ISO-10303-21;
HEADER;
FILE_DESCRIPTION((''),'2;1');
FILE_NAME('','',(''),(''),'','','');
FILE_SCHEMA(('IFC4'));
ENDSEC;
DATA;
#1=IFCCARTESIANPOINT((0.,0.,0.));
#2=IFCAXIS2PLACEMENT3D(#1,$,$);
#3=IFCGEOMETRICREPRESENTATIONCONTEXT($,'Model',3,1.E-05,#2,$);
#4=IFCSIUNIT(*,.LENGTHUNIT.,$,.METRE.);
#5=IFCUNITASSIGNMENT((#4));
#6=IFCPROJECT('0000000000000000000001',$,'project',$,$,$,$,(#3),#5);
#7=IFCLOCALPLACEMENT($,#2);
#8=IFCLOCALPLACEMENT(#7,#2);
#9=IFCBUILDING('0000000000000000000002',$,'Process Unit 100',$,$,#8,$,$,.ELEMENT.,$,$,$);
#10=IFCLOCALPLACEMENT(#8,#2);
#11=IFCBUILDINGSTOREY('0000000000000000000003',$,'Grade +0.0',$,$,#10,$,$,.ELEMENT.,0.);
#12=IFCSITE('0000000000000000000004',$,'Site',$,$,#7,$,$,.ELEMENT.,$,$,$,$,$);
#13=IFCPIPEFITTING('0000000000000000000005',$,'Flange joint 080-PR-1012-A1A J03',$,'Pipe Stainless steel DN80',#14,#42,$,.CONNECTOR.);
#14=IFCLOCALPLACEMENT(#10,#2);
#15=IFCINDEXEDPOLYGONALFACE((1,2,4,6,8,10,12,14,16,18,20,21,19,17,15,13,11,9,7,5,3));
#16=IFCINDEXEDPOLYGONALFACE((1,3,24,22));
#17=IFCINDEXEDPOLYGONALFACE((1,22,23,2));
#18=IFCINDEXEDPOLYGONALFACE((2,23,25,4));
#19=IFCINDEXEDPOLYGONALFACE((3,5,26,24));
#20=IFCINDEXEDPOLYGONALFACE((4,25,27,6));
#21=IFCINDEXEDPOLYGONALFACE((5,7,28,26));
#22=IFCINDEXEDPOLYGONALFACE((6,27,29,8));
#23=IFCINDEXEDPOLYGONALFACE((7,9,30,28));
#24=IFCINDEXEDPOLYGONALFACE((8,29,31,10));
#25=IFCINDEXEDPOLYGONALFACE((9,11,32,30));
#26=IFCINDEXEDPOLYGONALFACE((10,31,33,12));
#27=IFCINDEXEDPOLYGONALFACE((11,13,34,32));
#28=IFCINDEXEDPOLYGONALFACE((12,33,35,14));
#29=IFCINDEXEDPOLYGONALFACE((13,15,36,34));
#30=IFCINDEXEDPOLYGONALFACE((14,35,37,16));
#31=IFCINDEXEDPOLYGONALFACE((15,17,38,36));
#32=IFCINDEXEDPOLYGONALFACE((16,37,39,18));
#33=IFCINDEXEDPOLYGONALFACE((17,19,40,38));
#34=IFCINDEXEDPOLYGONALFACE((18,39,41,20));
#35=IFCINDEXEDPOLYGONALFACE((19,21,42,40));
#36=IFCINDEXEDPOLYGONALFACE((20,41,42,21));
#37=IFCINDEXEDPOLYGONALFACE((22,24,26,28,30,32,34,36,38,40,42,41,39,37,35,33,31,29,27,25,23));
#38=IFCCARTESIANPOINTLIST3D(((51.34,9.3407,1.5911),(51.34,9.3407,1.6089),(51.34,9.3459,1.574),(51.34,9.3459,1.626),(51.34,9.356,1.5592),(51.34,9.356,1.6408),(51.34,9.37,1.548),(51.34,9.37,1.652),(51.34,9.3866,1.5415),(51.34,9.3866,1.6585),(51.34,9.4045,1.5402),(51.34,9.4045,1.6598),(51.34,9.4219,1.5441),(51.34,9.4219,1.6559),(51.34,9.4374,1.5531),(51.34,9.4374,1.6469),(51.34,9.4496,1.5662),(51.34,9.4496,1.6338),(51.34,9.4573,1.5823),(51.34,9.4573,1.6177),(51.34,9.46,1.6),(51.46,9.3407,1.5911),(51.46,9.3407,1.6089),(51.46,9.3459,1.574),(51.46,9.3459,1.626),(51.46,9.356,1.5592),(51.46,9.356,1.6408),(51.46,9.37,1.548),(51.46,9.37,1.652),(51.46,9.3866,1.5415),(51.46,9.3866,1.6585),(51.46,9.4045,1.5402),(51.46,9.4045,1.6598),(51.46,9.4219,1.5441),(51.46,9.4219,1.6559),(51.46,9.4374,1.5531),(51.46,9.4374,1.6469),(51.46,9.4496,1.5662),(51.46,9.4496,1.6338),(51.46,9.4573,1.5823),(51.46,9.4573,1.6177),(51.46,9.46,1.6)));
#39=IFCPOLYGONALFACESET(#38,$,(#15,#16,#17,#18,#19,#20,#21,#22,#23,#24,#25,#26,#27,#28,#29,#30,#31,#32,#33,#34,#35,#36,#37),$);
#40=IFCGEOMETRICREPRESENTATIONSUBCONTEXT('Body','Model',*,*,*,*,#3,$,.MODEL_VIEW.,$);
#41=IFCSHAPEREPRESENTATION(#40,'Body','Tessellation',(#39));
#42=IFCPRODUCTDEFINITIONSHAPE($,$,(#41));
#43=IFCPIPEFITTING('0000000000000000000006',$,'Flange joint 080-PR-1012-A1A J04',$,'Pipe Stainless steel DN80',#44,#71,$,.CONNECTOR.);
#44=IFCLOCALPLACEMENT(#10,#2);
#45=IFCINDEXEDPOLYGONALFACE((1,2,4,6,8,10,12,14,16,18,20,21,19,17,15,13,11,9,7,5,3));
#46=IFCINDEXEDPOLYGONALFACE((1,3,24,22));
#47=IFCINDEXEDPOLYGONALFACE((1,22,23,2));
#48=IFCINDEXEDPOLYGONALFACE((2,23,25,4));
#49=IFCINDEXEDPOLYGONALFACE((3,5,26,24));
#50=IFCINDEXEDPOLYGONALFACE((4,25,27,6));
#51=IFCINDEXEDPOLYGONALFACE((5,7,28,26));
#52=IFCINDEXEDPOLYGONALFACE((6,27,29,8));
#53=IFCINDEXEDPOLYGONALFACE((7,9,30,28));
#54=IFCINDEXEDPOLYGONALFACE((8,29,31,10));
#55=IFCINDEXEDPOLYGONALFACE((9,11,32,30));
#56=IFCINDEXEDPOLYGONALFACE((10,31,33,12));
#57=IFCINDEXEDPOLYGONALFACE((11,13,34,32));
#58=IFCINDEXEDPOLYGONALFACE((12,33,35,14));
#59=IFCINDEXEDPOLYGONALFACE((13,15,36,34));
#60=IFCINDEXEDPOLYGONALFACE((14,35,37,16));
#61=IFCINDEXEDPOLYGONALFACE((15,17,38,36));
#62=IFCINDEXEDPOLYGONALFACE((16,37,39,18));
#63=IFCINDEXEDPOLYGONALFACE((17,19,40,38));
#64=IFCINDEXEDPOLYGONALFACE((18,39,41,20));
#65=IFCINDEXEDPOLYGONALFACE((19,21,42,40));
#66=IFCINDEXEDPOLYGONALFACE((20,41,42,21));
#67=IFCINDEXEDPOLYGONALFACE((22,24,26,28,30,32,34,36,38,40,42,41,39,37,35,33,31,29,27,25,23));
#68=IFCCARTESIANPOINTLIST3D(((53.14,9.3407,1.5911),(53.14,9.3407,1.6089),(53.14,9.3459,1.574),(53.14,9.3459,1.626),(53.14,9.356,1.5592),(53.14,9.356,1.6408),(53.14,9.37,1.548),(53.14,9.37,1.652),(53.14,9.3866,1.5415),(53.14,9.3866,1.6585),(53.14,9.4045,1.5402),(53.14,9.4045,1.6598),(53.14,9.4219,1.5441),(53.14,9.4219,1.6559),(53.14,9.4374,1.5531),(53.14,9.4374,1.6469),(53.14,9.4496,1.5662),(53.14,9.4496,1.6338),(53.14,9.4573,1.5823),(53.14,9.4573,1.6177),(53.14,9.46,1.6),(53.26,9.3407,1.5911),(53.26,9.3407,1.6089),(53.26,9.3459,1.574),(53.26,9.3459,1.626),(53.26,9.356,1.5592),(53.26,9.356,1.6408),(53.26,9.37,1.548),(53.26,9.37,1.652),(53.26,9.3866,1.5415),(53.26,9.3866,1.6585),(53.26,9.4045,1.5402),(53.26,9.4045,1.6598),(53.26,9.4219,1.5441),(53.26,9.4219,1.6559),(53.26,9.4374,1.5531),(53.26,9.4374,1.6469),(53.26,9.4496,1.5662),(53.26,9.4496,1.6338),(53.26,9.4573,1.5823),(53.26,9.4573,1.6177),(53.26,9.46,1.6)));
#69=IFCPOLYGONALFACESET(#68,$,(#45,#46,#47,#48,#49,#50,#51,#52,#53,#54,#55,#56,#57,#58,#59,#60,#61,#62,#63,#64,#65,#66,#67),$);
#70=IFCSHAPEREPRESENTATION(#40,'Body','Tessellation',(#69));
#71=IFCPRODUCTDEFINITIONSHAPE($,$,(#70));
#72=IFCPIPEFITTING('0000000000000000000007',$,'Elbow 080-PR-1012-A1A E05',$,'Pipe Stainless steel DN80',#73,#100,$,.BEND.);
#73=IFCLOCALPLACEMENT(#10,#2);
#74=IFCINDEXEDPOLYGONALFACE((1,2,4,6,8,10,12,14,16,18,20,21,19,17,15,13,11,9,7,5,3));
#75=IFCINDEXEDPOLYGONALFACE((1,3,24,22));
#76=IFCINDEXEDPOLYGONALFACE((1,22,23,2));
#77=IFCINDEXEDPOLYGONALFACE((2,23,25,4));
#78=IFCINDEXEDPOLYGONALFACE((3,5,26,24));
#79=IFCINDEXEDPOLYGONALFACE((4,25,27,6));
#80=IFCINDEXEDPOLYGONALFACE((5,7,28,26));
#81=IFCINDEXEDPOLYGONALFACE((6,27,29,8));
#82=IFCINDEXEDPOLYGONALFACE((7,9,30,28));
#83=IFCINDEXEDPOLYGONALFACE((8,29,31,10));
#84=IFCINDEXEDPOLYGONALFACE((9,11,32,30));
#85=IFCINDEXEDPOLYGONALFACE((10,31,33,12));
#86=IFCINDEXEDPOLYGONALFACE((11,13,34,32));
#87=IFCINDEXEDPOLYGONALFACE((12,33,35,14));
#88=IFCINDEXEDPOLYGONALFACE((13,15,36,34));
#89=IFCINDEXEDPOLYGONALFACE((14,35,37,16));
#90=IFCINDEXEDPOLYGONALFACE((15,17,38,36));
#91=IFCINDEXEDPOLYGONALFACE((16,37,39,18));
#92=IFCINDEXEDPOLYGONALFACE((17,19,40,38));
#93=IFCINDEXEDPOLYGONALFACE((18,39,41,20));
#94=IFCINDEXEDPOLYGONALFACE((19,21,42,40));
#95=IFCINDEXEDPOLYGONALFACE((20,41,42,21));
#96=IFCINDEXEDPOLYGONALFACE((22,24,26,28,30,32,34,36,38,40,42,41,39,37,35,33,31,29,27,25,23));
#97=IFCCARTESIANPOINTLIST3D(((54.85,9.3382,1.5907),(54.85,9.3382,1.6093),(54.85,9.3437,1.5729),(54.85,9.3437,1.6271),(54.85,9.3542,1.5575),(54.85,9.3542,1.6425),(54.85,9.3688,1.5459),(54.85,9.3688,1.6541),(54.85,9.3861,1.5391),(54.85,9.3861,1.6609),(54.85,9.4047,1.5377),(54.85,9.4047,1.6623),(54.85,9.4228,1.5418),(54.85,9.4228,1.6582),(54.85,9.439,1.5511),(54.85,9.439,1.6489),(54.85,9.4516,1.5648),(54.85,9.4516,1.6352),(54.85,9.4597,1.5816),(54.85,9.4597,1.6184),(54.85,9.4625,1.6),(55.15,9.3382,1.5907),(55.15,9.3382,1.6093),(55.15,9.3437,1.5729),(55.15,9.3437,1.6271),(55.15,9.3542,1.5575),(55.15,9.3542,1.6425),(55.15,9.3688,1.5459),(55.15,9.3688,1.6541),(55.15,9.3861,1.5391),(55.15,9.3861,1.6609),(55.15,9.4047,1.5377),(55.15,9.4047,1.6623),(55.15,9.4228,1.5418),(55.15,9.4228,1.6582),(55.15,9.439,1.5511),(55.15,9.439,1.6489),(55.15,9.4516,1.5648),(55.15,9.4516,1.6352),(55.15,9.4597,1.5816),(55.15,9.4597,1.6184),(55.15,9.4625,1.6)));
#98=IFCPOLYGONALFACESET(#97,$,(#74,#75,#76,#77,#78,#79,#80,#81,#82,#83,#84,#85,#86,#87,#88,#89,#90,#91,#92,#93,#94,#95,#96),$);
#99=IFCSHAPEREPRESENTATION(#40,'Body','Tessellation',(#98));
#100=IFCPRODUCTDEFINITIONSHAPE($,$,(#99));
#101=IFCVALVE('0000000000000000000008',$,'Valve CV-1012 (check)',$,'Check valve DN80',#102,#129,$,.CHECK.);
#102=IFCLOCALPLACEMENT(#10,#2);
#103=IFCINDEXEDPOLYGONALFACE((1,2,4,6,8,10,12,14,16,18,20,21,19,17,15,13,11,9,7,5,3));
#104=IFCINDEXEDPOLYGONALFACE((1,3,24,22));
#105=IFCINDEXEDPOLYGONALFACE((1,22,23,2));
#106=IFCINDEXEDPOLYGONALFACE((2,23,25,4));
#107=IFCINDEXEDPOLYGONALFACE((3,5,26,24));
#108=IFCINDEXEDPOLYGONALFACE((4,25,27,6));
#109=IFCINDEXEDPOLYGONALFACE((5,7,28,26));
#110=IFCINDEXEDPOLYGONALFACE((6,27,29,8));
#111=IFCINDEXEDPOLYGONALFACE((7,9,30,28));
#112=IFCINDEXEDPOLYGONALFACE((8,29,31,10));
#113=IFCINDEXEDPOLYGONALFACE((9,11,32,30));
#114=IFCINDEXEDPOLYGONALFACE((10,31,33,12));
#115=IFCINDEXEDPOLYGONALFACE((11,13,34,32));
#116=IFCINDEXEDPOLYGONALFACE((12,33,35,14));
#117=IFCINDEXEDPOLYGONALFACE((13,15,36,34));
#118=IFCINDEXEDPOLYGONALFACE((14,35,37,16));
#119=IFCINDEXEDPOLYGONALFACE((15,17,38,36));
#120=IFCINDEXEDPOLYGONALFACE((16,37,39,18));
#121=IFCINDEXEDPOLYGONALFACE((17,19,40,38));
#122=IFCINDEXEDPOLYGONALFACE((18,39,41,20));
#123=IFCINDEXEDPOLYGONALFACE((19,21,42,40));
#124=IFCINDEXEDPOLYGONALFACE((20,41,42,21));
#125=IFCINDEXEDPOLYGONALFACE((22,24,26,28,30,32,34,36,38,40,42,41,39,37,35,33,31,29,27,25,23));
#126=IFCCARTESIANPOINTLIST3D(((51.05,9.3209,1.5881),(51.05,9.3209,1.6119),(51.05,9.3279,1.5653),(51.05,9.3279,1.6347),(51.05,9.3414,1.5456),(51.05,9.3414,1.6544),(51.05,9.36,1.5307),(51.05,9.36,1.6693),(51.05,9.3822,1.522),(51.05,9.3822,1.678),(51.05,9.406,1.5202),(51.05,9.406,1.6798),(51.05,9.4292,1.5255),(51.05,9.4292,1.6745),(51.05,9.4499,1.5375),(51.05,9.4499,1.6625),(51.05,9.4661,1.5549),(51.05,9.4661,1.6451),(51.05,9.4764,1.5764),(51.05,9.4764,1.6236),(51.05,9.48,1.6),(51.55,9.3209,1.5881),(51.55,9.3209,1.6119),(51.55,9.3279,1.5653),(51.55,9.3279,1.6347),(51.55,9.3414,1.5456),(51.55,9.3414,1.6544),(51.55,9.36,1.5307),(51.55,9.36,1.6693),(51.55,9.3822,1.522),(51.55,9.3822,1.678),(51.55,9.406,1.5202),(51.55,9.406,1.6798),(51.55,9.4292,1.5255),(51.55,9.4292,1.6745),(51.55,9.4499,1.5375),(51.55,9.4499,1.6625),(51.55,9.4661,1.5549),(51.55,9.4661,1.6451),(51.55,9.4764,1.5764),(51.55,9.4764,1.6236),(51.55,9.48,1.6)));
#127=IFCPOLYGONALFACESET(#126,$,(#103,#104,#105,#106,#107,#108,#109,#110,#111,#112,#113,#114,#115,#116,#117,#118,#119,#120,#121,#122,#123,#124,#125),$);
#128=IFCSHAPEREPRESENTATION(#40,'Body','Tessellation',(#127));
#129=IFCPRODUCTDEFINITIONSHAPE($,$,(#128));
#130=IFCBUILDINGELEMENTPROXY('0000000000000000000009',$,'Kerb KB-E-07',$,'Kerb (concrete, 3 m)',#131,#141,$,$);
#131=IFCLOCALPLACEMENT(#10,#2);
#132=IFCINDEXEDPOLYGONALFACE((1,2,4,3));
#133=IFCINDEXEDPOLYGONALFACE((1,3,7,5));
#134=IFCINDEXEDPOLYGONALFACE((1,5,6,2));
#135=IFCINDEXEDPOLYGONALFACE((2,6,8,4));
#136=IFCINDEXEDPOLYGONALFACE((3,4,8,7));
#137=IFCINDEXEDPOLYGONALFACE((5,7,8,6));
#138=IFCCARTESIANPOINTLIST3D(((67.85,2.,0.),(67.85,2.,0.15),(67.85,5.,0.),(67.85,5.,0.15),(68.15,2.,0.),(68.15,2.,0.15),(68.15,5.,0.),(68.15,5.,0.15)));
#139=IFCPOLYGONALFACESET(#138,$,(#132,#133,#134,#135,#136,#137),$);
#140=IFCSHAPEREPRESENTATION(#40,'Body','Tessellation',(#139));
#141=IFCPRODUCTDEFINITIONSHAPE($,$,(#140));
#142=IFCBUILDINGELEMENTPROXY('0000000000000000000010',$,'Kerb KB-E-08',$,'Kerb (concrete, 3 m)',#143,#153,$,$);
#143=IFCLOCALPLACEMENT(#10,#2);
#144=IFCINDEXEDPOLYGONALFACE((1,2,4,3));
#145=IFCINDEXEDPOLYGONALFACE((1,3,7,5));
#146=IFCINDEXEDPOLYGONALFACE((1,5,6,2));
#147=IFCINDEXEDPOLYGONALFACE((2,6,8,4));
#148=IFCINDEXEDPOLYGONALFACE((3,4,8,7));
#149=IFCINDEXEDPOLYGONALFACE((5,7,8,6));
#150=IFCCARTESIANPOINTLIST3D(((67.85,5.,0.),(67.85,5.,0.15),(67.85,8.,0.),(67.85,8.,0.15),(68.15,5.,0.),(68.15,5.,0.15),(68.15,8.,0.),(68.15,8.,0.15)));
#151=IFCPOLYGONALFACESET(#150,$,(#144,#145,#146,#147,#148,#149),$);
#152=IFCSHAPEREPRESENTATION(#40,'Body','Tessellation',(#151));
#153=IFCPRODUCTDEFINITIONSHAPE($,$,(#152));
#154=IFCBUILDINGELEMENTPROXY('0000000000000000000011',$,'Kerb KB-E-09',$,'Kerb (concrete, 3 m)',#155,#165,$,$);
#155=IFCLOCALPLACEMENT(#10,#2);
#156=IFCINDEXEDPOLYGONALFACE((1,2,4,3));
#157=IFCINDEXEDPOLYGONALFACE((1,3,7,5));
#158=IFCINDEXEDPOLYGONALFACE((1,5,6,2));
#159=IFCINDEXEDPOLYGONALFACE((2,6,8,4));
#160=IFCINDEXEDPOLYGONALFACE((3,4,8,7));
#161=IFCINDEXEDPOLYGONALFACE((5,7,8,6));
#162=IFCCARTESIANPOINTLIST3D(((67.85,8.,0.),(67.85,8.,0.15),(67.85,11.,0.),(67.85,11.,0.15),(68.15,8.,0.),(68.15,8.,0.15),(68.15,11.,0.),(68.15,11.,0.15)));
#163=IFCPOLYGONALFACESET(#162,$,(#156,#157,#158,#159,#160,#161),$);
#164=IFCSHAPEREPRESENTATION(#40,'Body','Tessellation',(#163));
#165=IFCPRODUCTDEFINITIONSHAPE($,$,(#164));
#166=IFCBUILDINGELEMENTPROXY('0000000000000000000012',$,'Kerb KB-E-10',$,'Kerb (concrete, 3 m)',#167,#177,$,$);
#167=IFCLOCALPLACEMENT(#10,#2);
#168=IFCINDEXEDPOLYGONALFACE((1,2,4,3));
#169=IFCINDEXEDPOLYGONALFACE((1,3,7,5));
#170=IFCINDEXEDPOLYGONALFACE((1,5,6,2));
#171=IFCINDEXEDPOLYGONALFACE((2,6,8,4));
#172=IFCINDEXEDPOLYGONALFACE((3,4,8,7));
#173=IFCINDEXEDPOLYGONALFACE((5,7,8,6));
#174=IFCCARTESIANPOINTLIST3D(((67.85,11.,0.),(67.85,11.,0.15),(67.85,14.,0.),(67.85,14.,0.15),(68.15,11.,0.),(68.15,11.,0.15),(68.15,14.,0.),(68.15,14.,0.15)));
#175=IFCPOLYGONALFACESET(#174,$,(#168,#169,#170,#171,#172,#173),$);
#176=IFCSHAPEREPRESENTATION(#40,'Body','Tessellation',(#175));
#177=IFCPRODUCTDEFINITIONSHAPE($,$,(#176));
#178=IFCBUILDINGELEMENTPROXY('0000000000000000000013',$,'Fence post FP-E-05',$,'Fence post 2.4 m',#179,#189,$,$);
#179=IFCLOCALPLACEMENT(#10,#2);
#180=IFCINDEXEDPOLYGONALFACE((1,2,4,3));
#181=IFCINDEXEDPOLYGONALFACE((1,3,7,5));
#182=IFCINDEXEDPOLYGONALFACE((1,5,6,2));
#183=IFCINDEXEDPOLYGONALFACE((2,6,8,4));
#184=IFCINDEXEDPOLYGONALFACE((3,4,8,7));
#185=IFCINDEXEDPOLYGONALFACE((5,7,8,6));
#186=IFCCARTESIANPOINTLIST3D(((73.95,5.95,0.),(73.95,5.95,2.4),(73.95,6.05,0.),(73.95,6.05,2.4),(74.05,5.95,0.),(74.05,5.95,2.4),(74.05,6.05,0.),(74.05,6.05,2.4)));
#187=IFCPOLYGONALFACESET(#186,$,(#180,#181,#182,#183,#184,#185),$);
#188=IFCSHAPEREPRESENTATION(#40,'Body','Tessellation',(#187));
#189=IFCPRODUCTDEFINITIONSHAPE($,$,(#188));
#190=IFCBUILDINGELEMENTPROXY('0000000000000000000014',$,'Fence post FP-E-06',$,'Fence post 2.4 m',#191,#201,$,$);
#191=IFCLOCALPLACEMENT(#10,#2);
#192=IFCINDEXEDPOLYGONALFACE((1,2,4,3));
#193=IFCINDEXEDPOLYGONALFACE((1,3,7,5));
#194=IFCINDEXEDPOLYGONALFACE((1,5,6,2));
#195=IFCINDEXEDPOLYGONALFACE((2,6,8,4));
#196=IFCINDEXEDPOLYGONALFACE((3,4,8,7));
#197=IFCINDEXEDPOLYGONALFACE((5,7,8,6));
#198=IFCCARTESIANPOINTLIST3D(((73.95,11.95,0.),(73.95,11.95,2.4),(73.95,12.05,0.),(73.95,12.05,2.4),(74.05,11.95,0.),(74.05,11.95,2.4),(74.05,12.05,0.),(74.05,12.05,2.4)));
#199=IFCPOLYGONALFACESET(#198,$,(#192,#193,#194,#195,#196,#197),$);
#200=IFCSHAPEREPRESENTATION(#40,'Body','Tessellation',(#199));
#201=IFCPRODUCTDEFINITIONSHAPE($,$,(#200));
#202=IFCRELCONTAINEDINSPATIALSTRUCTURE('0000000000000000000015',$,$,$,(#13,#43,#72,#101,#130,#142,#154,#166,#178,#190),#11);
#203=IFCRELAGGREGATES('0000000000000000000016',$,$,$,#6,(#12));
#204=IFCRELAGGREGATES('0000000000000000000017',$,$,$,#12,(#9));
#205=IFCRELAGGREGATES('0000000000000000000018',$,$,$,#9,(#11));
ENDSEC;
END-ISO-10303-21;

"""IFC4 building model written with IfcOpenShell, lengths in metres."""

from ifc_helpers import new_model, si_unit, frame, origin, place, context, subcontext, project, spatial, rectangle, circle, extrude, element, save


model = new_model("IFC4")

# Units and contexts
model_context = context("Model", 3, precision=1e-05, world=origin())
body_context = subcontext(model_context, "Body", "Model", "MODEL_VIEW")
ifc_project = project(units=[si_unit("LENGTHUNIT", "METRE")], contexts=[model_context])

# Site, building, storey
site_placement = place(None, origin())
site = spatial("IfcSite", under=ifc_project, at=site_placement, Name="Site", CompositionType="ELEMENT")
building_placement = place(site_placement, origin())
building = spatial("IfcBuilding", under=site, at=building_placement, Name="Process Unit 100", CompositionType="ELEMENT")
storey_placement = place(building_placement, origin())
storey = spatial("IfcBuildingStorey", under=building, at=storey_placement, Name="Grade +0.0", CompositionType="ELEMENT", Elevation=0.0)

# Pipe fittings
for number, where, z_axis, x_axis, name in (
    (1, (51.34, 9.4, 1.6), (1.0, 0.0, 0.0), (0.0, 1.0, 0.0), "Flange joint 080-PR-1012-A1A J03"),
    (2, (53.14, 9.4, 1.6), (1.0, 0.0, 0.0), (0.0, 1.0, 0.0), "Flange joint 080-PR-1012-A1A J04"),
):
    element("IfcPipeFitting", number, at=place(storey_placement, frame(where, z_axis=z_axis, x_axis=x_axis)), inside=storey, Name=name, ObjectType="Pipe Stainless steel DN80", PredefinedType="CONNECTOR", context=body_context, shape_type="SweptSolid", body=[
        extrude(circle(Radius=0.06), origin(), (0.0, 0.0, 1.0), 0.12),
    ])
pipe_fitting_1_placement = place(storey_placement, frame((54.85, 9.4, 1.6), z_axis=(1.0, 0.0, 0.0), x_axis=(0.0, 1.0, 0.0)))
element("IfcPipeFitting", 3, at=pipe_fitting_1_placement, inside=storey, Name="Elbow 080-PR-1012-A1A E05", ObjectType="Pipe Stainless steel DN80", PredefinedType="BEND", context=body_context, shape_type="SweptSolid", body=[
    extrude(circle(Radius=0.0625), origin(), (0.0, 0.0, 1.0), 0.3),
])

# Valve
valve_1_placement = place(storey_placement, frame((51.05, 9.4, 1.6), z_axis=(1.0, 0.0, 0.0), x_axis=(0.0, 1.0, 0.0)))
element("IfcValve", 4, at=valve_1_placement, inside=storey, Name="Valve CV-1012 (check)", ObjectType="Check valve DN80", PredefinedType="CHECK", context=body_context, shape_type="SweptSolid", body=[
    extrude(circle(Radius=0.08), origin(), (0.0, 0.0, 1.0), 0.5),
])

# Building element proxies
for number, where, z_axis, x_axis, name in (
    (5, (68.0, 3.5, 0.0), (0.0, 0.0, 1.0), (1.0, 0.0, 0.0), "Kerb KB-E-07"),
    (6, (68.0, 6.5, 0.0), (0.0, 0.0, 1.0), (1.0, 0.0, 0.0), "Kerb KB-E-08"),
    (7, (68.0, 9.5, 0.0), (0.0, 0.0, 1.0), (1.0, 0.0, 0.0), "Kerb KB-E-09"),
    (8, (68.0, 12.5, 0.0), (0.0, 0.0, 1.0), (1.0, 0.0, 0.0), "Kerb KB-E-10"),
):
    element("IfcBuildingElementProxy", number, at=place(storey_placement, frame(where, z_axis=z_axis, x_axis=x_axis)), inside=storey, Name=name, ObjectType="Kerb (concrete, 3 m)", context=body_context, shape_type="SweptSolid", body=[
        extrude(rectangle(XDim=0.3, YDim=3.0), origin(), (0.0, 0.0, 1.0), 0.15),
    ])
for number, where, z_axis, x_axis, name in (
    (9, (74.0, 6.0, 0.0), (0.0, 0.0, 1.0), (1.0, 0.0, 0.0), "Fence post FP-E-05"),
    (10, (74.0, 12.0, 0.0), (0.0, 0.0, 1.0), (1.0, 0.0, 0.0), "Fence post FP-E-06"),
):
    element("IfcBuildingElementProxy", number, at=place(storey_placement, frame(where, z_axis=z_axis, x_axis=x_axis)), inside=storey, Name=name, ObjectType="Fence post 2.4 m", context=body_context, shape_type="SweptSolid", body=[
        extrude(rectangle(XDim=0.1, YDim=0.1), origin(), (0.0, 0.0, 1.0), 2.4),
    ])

save(model, "model.ifc")
